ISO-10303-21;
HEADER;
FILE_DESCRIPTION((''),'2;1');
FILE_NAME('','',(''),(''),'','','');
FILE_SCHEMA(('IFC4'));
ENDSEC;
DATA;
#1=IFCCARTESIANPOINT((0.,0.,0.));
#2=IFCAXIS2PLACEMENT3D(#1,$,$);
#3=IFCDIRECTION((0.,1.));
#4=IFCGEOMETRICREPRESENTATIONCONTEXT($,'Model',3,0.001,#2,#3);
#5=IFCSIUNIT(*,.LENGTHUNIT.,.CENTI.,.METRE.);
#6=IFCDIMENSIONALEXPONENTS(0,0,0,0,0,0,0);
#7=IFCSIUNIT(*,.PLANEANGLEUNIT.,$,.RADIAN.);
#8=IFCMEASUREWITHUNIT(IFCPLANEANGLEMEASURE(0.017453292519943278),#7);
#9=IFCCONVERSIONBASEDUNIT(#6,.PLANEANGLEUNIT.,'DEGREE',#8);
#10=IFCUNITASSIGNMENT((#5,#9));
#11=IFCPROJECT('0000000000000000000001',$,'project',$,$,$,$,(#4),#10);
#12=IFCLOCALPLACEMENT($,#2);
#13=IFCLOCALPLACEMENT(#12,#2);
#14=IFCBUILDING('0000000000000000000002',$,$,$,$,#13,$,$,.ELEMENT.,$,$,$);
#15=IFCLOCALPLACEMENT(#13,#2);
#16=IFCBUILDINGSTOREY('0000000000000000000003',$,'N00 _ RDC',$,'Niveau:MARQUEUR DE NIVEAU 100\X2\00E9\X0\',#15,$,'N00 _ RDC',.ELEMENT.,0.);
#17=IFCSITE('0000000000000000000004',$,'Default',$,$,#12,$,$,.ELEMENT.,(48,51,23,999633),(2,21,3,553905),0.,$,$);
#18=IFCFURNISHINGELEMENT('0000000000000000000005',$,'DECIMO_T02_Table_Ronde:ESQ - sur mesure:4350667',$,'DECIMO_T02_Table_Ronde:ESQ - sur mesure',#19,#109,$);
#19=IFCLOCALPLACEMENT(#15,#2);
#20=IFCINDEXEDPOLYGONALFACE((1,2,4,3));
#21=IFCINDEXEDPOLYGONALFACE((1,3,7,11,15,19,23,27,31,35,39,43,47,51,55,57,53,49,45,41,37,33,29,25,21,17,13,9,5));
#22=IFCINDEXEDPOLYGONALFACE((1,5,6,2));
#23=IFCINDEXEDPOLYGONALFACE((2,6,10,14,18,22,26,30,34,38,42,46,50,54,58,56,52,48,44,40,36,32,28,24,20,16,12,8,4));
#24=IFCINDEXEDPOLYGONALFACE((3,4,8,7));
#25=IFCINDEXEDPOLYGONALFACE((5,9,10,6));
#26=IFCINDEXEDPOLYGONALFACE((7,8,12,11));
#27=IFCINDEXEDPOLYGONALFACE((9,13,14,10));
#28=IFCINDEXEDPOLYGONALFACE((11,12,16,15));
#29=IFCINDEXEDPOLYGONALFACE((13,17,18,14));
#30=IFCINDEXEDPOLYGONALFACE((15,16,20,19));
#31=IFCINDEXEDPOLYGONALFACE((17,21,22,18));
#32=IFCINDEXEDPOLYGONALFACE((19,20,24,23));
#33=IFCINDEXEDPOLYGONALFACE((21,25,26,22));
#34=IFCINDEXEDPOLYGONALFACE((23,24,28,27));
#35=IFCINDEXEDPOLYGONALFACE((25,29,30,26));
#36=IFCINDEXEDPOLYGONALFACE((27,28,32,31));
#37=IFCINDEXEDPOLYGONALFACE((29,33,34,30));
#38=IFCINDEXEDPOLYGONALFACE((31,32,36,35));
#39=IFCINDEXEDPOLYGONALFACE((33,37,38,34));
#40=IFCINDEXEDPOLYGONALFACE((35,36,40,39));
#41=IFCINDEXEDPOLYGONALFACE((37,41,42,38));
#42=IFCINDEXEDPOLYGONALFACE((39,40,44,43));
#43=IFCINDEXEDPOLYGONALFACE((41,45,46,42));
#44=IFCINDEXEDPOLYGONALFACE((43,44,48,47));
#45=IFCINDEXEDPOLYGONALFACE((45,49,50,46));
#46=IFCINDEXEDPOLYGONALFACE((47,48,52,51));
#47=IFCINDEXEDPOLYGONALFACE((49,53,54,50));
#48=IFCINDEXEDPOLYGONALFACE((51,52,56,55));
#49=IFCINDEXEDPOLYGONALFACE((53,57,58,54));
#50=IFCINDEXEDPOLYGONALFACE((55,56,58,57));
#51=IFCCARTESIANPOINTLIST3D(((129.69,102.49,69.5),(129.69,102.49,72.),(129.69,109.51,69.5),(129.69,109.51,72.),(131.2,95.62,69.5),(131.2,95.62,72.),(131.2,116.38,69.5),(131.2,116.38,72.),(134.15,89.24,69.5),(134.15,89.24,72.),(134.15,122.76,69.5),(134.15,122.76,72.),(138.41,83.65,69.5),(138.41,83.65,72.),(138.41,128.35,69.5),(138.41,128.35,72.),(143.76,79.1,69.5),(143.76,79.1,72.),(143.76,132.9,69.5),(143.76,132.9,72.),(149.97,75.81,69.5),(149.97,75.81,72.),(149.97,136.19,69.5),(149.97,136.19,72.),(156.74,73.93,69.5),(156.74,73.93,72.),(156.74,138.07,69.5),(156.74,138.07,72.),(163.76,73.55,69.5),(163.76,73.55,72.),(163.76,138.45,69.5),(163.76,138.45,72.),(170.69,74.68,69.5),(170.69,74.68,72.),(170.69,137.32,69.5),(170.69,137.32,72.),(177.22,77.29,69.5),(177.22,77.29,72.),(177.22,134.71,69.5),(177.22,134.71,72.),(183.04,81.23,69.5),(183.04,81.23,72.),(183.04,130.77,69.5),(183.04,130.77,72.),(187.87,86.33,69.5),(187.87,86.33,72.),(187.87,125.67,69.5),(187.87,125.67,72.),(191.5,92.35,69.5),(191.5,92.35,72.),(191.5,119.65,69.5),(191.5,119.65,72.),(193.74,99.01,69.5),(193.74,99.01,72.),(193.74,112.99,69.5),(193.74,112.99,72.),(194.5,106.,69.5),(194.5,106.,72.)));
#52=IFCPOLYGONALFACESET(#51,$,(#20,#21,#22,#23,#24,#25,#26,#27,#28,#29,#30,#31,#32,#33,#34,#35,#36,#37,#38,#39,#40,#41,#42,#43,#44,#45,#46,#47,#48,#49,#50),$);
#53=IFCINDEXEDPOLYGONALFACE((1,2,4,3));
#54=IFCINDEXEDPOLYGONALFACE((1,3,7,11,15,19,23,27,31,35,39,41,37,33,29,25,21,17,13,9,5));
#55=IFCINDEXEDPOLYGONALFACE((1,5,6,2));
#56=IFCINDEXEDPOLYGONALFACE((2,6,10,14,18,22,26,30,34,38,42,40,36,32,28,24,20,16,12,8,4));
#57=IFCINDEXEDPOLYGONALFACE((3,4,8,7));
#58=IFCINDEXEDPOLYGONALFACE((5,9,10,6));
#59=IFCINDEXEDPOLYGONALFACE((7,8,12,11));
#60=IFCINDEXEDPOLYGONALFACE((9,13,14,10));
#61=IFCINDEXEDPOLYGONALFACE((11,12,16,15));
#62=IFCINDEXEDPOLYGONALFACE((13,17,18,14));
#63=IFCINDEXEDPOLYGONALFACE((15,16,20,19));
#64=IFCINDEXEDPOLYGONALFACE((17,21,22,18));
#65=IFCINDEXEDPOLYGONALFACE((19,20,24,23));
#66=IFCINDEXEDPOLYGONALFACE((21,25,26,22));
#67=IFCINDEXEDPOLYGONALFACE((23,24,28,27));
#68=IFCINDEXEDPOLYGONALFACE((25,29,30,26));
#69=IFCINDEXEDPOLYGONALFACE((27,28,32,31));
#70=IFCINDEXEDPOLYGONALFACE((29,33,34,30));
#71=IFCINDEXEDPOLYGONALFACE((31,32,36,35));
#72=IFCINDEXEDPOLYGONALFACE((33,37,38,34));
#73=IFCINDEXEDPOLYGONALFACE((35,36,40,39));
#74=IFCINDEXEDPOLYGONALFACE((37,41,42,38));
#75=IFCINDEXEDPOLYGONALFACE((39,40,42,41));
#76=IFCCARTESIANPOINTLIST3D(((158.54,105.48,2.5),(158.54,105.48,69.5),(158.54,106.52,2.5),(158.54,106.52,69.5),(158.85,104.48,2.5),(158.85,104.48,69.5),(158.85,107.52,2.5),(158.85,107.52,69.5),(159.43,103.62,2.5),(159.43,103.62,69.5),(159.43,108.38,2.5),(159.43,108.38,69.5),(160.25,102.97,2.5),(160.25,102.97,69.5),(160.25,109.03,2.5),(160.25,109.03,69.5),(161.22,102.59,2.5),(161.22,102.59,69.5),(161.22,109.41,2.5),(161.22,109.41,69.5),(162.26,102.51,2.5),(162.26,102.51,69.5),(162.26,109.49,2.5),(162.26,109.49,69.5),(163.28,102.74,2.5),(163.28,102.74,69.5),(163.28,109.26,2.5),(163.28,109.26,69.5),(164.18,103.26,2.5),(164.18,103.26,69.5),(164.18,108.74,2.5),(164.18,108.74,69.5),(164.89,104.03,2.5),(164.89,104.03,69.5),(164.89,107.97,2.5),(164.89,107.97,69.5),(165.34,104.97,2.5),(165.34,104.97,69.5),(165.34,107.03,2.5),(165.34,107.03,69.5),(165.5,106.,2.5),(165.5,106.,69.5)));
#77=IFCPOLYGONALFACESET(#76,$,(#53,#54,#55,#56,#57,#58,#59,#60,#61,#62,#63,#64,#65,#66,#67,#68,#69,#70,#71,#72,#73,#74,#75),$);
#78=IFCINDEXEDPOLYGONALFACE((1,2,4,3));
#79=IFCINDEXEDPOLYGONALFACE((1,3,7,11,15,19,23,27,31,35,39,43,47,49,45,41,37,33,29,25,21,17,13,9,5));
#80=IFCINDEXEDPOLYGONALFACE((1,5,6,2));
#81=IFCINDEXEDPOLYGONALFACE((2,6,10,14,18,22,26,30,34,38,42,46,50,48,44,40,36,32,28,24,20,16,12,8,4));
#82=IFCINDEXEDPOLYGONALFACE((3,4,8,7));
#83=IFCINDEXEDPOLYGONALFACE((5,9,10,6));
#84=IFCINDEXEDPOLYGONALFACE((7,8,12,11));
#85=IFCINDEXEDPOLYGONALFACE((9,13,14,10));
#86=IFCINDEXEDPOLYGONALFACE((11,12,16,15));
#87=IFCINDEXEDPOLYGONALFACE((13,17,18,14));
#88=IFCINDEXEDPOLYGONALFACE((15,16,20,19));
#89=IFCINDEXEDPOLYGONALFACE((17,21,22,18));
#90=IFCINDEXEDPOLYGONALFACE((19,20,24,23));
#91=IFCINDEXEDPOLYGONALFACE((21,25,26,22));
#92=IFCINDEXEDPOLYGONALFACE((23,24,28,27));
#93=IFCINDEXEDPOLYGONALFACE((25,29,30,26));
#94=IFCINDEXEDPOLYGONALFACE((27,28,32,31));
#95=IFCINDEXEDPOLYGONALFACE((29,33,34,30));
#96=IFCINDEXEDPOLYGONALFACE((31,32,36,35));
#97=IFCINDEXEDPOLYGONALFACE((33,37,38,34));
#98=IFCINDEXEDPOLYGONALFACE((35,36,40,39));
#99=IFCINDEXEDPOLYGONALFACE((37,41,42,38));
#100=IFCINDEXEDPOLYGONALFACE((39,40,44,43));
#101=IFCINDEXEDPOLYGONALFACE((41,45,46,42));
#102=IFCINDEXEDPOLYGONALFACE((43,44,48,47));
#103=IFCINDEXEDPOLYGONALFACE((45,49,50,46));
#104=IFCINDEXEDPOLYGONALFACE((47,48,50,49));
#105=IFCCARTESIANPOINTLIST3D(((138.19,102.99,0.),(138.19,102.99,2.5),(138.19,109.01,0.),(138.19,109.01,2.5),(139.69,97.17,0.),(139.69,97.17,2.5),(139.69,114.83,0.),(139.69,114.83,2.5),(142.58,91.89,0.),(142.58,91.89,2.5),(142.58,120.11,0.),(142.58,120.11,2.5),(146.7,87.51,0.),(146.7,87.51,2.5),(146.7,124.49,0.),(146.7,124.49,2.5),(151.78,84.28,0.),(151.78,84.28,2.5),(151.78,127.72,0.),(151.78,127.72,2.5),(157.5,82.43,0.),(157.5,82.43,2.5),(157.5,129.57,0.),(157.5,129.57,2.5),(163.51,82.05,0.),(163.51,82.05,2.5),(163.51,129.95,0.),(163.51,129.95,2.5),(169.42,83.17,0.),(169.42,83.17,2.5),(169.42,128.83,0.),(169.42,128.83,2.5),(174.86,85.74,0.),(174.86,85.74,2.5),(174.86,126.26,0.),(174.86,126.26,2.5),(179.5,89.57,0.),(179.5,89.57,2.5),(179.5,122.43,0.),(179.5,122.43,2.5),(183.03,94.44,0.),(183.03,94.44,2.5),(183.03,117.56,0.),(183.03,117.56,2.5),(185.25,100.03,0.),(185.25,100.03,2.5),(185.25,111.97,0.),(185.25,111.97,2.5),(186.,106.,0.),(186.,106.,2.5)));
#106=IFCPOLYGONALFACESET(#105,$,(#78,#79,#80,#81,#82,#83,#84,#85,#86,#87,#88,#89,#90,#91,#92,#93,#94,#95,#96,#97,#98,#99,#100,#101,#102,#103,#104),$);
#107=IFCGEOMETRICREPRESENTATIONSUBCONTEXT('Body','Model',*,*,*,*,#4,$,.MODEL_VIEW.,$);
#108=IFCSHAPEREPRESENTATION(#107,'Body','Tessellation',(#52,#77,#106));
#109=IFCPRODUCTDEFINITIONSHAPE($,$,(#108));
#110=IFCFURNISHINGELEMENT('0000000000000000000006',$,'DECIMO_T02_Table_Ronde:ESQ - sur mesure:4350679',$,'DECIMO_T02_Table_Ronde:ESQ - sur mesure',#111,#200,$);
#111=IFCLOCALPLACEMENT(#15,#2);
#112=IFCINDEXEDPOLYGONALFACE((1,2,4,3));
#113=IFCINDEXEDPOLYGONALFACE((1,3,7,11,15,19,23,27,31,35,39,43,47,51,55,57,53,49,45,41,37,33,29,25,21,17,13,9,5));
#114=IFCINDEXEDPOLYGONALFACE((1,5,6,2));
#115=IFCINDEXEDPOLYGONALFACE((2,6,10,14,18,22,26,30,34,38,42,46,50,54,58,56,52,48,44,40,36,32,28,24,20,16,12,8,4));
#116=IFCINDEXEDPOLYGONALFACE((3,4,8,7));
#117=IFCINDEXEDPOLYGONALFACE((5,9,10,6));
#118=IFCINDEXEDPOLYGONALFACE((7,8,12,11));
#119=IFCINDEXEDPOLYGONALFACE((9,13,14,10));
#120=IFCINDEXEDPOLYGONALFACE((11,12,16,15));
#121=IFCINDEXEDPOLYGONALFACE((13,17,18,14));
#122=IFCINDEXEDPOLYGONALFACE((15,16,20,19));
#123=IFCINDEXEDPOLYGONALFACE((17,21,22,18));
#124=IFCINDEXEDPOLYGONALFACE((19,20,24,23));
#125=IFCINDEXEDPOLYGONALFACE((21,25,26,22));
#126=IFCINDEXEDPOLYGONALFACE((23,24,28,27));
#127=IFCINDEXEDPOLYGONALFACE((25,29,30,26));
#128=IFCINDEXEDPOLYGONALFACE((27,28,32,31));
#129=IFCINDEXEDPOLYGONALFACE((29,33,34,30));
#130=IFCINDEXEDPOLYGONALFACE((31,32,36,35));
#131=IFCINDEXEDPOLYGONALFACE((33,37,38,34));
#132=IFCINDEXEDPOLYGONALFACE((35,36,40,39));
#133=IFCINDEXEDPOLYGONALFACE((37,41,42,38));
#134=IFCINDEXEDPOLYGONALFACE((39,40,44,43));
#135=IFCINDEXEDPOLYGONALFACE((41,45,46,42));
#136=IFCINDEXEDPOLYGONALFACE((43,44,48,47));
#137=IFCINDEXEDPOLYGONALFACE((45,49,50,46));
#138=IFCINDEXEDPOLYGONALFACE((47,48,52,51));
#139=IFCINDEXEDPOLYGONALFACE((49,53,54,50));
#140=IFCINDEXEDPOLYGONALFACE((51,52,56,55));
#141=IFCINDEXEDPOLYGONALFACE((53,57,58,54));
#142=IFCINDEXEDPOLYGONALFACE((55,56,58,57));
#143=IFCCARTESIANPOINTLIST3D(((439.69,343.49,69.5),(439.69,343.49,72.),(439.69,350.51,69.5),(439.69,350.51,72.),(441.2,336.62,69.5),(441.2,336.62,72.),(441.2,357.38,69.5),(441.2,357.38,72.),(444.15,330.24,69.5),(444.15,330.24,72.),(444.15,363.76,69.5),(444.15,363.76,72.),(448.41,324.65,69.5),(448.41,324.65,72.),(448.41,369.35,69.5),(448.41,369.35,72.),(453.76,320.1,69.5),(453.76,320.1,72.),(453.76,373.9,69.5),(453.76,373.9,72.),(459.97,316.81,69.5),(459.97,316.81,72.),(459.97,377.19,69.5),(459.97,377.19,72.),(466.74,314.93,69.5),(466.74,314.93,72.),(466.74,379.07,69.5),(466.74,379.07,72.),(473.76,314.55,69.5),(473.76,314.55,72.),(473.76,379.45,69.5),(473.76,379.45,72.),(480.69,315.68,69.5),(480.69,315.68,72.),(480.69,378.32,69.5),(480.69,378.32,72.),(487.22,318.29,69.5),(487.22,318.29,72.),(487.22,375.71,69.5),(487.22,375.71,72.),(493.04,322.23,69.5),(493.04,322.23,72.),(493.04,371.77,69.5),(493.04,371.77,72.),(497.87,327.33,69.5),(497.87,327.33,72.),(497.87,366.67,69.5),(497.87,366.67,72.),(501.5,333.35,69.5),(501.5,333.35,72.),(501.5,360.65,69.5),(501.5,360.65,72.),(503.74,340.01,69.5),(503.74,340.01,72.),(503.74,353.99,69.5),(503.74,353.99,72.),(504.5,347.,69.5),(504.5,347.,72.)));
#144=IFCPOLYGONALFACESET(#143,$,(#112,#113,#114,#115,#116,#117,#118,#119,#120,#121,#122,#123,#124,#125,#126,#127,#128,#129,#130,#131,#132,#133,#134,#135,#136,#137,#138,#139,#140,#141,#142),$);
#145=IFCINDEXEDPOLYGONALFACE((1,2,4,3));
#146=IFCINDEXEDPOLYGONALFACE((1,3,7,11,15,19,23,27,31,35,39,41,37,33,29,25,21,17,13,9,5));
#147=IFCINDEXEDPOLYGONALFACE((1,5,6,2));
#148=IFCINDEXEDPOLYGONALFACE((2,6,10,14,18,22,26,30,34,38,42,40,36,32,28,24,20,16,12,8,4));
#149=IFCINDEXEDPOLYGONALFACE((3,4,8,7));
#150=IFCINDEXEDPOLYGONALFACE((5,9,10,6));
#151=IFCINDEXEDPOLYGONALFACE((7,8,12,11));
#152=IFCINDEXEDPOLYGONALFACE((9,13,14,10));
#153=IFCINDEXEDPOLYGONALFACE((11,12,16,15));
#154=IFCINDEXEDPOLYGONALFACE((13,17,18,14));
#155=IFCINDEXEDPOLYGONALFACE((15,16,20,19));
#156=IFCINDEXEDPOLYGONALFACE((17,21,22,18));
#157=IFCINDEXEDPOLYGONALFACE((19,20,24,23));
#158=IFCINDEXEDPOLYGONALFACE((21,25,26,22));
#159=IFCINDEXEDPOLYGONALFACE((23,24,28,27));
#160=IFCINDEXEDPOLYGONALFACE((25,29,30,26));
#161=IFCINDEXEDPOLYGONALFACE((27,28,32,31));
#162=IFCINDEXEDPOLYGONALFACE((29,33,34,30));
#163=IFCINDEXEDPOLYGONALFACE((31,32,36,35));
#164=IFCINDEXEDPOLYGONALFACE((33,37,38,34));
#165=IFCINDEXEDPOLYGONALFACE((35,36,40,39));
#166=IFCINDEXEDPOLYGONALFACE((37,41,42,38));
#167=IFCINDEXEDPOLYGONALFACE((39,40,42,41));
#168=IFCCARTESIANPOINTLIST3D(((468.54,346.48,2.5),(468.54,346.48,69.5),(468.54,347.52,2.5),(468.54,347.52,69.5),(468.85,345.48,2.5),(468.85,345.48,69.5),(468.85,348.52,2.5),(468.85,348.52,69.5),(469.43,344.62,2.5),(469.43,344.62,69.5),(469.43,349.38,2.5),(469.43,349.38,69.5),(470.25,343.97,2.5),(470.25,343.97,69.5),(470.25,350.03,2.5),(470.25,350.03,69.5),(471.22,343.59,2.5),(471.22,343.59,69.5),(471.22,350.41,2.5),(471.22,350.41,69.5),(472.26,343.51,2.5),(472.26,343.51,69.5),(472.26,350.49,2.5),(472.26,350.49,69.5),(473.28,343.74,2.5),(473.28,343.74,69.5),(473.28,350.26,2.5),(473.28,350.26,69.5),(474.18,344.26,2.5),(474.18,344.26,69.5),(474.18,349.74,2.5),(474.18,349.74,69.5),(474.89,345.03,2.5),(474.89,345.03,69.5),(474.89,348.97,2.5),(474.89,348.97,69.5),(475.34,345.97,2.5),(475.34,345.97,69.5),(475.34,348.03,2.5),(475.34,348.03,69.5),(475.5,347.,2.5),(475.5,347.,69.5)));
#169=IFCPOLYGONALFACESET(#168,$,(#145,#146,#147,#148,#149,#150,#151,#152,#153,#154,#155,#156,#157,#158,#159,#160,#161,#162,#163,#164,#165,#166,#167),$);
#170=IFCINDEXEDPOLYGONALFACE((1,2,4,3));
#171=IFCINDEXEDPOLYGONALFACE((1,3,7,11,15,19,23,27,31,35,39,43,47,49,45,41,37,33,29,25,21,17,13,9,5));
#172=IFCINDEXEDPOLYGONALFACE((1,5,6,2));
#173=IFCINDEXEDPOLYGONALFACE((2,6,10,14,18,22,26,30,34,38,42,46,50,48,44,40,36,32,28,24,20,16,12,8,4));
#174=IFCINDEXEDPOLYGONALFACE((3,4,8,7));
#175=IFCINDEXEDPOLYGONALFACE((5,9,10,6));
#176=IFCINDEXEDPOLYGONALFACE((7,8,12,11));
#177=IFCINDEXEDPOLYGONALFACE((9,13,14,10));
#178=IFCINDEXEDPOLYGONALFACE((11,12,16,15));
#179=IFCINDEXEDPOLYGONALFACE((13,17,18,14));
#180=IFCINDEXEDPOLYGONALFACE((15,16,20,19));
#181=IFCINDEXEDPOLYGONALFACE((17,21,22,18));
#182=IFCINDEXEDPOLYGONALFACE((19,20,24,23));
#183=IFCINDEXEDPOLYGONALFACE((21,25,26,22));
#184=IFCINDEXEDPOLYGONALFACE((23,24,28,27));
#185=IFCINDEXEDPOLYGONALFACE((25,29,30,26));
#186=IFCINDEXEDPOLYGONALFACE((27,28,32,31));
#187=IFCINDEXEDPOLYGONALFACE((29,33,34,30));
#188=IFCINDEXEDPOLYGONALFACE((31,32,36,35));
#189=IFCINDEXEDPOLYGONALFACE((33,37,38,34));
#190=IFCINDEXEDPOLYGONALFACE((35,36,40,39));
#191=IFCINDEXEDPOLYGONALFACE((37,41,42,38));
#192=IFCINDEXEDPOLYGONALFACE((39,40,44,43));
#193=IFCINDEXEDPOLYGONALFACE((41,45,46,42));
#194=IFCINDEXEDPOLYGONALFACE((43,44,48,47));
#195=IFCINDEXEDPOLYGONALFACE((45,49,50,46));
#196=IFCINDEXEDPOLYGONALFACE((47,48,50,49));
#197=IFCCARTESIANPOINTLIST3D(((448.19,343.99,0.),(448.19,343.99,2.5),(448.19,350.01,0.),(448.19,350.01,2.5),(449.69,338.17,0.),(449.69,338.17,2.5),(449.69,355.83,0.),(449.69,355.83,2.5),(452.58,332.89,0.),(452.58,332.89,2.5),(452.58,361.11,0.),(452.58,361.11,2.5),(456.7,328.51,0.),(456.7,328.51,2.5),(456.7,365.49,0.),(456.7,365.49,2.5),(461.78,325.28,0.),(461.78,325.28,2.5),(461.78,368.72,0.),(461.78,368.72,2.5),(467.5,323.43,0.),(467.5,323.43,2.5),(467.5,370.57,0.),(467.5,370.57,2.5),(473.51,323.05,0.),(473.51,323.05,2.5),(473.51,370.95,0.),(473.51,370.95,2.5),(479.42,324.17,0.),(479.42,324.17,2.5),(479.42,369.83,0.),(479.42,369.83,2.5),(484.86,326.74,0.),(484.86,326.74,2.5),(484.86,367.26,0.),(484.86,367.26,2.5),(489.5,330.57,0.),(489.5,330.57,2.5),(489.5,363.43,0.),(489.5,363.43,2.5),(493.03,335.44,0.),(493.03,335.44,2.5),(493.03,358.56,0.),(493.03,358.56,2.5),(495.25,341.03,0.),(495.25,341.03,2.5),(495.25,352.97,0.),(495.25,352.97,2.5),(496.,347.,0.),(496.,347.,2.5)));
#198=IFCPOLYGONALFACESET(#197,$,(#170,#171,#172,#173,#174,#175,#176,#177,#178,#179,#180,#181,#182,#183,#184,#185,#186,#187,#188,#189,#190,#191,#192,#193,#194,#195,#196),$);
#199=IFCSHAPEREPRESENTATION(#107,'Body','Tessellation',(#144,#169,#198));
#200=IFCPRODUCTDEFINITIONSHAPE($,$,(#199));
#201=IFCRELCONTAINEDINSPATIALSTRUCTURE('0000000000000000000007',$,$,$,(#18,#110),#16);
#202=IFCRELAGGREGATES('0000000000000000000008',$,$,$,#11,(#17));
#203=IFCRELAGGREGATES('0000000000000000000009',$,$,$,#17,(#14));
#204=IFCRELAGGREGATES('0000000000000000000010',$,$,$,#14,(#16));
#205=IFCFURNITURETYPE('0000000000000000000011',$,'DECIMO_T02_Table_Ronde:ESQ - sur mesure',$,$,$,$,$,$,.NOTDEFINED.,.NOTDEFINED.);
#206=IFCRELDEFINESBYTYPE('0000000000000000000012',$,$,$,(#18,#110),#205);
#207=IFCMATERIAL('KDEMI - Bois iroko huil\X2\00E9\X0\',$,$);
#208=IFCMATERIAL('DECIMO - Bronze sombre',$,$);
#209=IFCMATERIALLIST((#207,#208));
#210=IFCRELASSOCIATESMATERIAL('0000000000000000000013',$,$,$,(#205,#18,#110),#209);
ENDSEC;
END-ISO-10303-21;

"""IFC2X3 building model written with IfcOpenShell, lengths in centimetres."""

from ifc_helpers import new_model, entity, si_unit, converted_unit, direction, frame, frame_2d, origin, place, context, subcontext, project, spatial, circle, extrude, source, transform, mapped, material, material_list, type_object, type_shapes, element, save


model = new_model("IFC2X3")

# Units and contexts
model_context = context("Model", 3, precision=0.001, world=origin(), true_north=direction((0.0, 1.0)))
body_context = subcontext(model_context, "Body", "Model", "MODEL_VIEW")
ifc_project = project(units=[si_unit("LENGTHUNIT", "METRE", prefix="CENTI"), converted_unit("PLANEANGLEUNIT", "DEGREE", entity("IfcPlaneAngleMeasure", 0.017453292519943278), si_unit("PLANEANGLEUNIT", "RADIAN"), dimensions=[0, 0, 0, 0, 0, 0, 0])], contexts=[model_context])

# Site, building, storey
site_placement = place(None, origin())
site = spatial("IfcSite", under=ifc_project, at=site_placement, Name="Default", CompositionType="ELEMENT", RefLatitude=(48, 51, 23, 999633), RefLongitude=(2, 21, 3, 553905), RefElevation=0.0)
building_placement = place(site_placement, origin())
building = spatial("IfcBuilding", under=site, at=building_placement, CompositionType="ELEMENT")
storey_placement = place(building_placement, origin())
storey = spatial("IfcBuildingStorey", under=building, at=storey_placement, Name="N00 _ RDC", ObjectType="Niveau:MARQUEUR DE NIVEAU 100é", LongName="N00 _ RDC", CompositionType="ELEMENT", Elevation=0.0)

# Furnishing elements
ifc_material_1 = material(Name="DECIMO - Bronze sombre")
ifc_material_2 = material(Name="KDEMI - Bois iroko huilé")
ifc_material_list_1 = material_list([ifc_material_2, ifc_material_1])
furniture_type_1 = type_object("IfcFurnitureType", Name="DECIMO_T02_Table_Ronde:ESQ - sur mesure", AssemblyPlace="NOTDEFINED", material=ifc_material_list_1)
shared_shape_1 = source(origin(), body_context, "Body", "SweptSolid", [
    extrude(circle(Radius=32.5, at=frame_2d((0.0, 0.0), x_axis=(1.0, 0.0))), frame((0.0, 0.0, 69.5)), (0.0, 0.0, 1.0), 2.5),
    extrude(circle(Radius=3.5, at=frame_2d((0.0, 0.0), x_axis=(1.0, 0.0))), frame((0.0, 0.0, 2.5)), (0.0, 0.0, 1.0), 67.0),
    extrude(circle(Radius=24.0, at=frame_2d((0.0, 0.0), x_axis=(1.0, 0.0))), origin(), (0.0, 0.0, 1.0), 2.5),
])
type_shapes(furniture_type_1, [shared_shape_1])
furnishing_1_placement = place(storey_placement, frame((162.0, 106.0, 0.0)))
element("IfcFurnishingElement", 1, at=furnishing_1_placement, inside=storey, type_object=furniture_type_1, material=ifc_material_list_1, Name="DECIMO_T02_Table_Ronde:ESQ - sur mesure:4350667", ObjectType="DECIMO_T02_Table_Ronde:ESQ - sur mesure", context=body_context, shape_type="MappedRepresentation", body=[
    mapped(shared_shape_1, transform((0.0, 0.0, 0.0), scale=1.0)),
])
furnishing_2_placement = place(storey_placement, frame((472.0, 347.0, 0.0), z_axis=(0.0, 0.0, 1.0), x_axis=(1.0, 0.0, 0.0)))
element("IfcFurnishingElement", 2, at=furnishing_2_placement, inside=storey, type_object=furniture_type_1, material=ifc_material_list_1, Name="DECIMO_T02_Table_Ronde:ESQ - sur mesure:4350679", ObjectType="DECIMO_T02_Table_Ronde:ESQ - sur mesure", context=body_context, shape_type="MappedRepresentation", body=[
    mapped(shared_shape_1, transform((0.0, 0.0, 0.0), scale=1.0)),
])

save(model, "model.ifc")
